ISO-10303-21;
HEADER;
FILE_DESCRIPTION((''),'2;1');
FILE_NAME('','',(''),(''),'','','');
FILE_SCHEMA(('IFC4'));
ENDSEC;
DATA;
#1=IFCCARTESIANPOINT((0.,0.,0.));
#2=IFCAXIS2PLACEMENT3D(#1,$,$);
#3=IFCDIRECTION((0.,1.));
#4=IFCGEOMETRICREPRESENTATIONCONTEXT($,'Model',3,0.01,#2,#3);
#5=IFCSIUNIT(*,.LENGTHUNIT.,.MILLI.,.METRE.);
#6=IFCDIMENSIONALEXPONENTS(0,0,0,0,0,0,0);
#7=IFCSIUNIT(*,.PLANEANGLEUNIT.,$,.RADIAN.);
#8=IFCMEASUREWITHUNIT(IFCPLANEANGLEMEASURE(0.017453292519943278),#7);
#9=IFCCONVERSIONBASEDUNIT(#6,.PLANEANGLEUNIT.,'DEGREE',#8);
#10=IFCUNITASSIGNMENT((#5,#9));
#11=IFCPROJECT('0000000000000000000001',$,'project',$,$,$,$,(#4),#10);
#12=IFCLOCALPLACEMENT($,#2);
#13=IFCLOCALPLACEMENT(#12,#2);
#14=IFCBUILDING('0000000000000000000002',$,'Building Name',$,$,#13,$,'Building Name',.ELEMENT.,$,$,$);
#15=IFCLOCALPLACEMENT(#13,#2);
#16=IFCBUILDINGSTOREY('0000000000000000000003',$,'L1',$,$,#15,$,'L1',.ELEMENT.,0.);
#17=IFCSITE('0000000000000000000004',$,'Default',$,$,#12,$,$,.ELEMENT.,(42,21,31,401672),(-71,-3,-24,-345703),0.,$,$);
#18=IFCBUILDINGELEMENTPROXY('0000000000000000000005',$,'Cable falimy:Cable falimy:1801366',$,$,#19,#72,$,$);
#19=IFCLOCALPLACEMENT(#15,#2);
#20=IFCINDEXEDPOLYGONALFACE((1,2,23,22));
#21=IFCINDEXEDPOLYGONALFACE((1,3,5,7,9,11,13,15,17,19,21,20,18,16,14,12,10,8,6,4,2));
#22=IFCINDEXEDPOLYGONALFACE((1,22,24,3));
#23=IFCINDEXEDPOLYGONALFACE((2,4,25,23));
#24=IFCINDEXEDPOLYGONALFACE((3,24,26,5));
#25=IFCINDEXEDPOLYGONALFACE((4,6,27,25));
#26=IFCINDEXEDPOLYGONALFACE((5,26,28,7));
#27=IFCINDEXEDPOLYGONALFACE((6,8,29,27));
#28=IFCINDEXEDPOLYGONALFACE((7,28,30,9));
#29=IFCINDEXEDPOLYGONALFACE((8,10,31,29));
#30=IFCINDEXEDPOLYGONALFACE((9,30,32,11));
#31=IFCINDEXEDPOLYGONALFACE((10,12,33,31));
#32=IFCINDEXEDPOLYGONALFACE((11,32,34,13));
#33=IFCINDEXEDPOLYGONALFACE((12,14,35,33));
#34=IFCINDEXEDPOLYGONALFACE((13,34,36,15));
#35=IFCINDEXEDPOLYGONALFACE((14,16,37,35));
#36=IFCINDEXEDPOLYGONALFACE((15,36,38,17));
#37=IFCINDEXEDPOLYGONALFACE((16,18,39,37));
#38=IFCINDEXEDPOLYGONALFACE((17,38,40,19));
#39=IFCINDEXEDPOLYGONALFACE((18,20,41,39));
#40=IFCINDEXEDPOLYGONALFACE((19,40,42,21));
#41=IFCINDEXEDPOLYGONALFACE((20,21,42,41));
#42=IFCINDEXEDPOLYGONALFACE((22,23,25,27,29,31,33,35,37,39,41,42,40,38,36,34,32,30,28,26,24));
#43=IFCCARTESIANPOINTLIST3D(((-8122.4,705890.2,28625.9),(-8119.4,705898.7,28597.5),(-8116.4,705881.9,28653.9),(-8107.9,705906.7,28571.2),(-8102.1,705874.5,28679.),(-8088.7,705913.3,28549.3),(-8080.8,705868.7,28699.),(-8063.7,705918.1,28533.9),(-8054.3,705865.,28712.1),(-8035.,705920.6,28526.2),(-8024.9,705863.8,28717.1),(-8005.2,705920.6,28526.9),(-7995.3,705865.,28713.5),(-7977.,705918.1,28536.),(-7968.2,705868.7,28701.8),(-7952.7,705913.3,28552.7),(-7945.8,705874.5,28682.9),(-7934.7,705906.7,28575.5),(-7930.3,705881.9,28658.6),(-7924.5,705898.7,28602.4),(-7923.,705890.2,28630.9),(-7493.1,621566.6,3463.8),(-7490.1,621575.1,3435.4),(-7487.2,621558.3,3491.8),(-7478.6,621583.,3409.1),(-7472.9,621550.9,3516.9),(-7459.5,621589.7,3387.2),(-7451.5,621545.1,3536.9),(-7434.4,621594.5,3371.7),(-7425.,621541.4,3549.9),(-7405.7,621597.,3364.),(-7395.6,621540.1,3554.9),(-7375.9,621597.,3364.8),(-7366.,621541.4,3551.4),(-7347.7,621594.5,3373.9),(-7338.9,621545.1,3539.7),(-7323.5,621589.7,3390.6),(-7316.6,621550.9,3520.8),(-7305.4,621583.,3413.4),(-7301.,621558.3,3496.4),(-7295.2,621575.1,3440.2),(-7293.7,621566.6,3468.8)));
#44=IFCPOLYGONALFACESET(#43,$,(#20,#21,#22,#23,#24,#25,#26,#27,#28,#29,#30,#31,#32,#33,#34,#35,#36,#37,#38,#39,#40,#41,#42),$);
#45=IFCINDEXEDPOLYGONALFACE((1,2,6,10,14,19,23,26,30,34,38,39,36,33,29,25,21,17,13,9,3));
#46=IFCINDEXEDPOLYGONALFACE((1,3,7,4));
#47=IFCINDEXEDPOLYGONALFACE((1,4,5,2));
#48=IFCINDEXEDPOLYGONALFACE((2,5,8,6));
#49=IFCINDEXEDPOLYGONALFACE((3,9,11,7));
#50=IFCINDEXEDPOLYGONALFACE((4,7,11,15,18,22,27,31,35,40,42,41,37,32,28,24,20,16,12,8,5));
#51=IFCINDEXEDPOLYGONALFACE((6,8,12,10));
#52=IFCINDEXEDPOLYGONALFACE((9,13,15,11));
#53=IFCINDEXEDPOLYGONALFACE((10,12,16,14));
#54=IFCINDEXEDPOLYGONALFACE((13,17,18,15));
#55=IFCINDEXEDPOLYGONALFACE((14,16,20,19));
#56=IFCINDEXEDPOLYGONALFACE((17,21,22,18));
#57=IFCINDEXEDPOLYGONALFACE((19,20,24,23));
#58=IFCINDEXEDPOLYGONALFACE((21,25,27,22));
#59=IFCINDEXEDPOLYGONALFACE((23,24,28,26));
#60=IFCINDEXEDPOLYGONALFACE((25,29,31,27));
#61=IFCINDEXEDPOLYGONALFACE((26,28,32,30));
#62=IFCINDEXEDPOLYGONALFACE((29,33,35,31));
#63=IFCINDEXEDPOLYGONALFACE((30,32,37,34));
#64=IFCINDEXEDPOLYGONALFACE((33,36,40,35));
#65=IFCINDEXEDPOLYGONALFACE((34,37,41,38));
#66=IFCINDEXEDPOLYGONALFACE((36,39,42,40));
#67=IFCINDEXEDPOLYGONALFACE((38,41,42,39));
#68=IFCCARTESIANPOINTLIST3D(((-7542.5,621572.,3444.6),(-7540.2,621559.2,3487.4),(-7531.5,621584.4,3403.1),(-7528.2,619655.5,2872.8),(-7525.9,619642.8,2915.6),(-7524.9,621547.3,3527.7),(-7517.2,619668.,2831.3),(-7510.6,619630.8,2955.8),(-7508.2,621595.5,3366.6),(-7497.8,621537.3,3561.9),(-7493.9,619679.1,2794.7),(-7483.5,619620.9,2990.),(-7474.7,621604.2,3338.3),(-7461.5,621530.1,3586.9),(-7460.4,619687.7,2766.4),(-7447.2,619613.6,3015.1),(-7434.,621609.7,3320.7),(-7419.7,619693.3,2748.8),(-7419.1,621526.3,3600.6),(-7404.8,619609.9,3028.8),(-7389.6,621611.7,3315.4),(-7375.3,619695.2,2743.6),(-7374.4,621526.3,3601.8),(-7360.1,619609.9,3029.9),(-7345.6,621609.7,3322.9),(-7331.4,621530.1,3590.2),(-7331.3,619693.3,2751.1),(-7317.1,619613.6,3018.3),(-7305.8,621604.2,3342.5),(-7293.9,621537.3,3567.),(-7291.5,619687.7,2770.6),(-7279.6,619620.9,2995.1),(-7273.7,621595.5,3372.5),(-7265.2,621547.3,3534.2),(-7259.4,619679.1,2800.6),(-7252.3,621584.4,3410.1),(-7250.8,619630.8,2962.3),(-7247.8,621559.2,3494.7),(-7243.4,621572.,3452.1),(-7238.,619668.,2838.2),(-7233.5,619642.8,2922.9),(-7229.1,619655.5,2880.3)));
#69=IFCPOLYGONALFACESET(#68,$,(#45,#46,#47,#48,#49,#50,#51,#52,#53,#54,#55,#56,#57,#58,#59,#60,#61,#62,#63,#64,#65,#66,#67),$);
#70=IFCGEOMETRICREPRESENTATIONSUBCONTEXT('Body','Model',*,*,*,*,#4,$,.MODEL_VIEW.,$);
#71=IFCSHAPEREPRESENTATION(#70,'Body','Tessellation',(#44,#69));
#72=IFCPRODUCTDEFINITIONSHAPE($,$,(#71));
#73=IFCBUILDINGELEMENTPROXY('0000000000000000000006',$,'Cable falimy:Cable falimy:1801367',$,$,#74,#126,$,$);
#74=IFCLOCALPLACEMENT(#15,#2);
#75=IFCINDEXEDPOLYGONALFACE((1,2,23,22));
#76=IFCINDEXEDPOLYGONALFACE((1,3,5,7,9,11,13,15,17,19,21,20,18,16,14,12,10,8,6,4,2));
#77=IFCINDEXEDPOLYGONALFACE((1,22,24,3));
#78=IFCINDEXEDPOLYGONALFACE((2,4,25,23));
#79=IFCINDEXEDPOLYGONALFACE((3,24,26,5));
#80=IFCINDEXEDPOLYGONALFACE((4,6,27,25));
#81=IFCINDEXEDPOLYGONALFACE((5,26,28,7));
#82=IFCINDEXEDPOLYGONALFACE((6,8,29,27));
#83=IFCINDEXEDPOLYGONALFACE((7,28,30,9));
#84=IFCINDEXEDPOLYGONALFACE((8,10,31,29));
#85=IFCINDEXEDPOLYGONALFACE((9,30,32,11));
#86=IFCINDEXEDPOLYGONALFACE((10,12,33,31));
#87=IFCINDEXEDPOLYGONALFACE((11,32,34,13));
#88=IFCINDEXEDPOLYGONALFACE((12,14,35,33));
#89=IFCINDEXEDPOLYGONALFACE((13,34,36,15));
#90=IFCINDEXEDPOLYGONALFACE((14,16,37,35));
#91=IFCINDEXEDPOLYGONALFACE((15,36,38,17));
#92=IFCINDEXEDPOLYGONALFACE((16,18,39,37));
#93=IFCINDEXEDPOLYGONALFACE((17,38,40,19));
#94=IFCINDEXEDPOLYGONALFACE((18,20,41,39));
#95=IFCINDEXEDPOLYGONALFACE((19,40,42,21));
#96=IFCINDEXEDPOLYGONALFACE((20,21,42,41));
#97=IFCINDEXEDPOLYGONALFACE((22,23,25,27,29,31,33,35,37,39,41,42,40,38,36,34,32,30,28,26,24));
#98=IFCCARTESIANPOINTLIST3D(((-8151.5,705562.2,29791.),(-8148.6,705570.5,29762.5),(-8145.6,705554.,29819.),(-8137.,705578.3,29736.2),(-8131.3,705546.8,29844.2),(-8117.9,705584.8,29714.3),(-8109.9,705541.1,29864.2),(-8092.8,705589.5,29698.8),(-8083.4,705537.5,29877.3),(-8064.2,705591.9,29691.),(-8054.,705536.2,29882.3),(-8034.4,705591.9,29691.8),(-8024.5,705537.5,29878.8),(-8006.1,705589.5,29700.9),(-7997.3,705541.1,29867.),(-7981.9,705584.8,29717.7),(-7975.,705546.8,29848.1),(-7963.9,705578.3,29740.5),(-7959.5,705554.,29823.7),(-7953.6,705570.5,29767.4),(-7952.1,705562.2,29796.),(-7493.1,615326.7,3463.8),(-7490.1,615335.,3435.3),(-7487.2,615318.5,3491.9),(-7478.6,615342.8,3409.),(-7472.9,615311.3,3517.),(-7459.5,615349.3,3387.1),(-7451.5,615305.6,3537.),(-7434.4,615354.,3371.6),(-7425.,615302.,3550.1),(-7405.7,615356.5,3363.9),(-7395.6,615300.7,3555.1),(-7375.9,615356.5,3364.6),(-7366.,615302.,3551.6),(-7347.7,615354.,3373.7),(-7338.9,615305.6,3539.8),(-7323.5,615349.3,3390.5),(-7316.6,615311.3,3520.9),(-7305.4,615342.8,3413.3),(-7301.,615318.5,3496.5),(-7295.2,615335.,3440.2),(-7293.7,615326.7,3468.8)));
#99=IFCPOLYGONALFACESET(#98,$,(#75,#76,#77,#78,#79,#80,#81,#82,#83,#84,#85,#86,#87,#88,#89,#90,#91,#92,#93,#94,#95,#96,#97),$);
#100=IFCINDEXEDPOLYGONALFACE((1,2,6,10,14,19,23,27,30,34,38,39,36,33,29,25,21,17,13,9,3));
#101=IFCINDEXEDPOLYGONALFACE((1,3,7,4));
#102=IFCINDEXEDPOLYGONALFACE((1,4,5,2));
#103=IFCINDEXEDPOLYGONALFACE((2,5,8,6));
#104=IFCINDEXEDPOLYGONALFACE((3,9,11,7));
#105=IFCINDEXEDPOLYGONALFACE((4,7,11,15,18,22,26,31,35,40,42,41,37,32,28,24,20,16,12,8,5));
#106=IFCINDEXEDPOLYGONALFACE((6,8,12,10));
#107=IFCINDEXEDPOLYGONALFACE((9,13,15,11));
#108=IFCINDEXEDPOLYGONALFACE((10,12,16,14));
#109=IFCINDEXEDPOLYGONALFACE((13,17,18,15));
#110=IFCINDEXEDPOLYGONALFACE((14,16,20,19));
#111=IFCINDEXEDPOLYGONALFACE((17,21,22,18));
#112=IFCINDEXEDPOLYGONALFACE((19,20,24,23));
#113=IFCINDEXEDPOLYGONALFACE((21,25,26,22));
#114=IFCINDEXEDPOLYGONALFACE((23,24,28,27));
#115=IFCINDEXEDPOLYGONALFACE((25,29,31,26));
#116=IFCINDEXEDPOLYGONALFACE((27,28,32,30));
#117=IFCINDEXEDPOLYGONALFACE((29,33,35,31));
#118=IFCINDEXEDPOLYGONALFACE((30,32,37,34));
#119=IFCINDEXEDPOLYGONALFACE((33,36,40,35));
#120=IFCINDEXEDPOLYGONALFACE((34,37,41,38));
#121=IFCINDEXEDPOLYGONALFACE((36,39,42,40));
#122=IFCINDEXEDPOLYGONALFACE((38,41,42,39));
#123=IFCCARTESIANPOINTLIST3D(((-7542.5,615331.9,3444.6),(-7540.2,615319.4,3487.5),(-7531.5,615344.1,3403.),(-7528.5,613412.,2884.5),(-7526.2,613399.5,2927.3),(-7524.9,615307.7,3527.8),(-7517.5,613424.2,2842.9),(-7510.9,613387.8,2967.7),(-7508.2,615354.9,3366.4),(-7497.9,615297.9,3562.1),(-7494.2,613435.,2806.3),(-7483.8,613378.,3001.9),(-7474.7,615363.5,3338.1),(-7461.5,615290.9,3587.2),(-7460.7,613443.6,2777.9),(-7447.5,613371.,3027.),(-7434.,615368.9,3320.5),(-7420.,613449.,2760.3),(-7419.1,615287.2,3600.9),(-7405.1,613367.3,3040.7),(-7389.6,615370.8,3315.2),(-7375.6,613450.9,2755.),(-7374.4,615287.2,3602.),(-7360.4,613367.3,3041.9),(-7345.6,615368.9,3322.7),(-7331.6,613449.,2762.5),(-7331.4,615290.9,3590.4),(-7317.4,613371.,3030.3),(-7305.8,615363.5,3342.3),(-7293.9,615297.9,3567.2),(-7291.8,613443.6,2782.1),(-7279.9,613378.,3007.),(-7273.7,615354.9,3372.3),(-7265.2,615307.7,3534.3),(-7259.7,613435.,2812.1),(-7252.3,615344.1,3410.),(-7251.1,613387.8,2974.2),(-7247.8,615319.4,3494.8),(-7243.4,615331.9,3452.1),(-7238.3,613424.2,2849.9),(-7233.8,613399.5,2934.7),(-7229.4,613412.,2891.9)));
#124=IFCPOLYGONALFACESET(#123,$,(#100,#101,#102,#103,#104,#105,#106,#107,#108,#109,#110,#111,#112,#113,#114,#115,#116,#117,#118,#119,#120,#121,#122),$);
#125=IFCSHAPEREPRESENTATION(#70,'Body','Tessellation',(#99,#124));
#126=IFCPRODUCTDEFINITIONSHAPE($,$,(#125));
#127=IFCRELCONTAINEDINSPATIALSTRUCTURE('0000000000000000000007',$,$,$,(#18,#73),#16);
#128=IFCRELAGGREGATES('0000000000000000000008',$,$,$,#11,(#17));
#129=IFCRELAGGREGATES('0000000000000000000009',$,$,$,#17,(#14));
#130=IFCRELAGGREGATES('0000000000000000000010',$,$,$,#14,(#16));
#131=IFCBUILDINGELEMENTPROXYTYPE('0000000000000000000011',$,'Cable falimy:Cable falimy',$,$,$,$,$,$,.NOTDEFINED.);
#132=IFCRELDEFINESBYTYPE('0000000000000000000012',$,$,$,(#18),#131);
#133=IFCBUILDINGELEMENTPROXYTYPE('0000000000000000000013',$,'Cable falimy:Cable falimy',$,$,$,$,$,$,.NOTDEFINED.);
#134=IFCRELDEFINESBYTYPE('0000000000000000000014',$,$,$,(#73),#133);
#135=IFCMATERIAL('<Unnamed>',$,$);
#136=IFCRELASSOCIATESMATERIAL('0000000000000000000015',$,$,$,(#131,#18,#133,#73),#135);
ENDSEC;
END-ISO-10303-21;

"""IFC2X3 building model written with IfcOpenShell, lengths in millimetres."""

from ifc_helpers import new_model, entity, si_unit, converted_unit, direction, frame, frame_2d, origin, place, context, subcontext, project, spatial, circle, extrude, source, transform, mapped, material, type_object, type_shapes, element, save


model = new_model("IFC2X3")

# Units and contexts
model_context = context("Model", 3, precision=0.01, world=origin(), true_north=direction((0.0, 1.0)))
body_context = subcontext(model_context, "Body", "Model", "MODEL_VIEW")
ifc_project = project(units=[si_unit("LENGTHUNIT", "METRE", prefix="MILLI"), converted_unit("PLANEANGLEUNIT", "DEGREE", entity("IfcPlaneAngleMeasure", 0.017453292519943278), si_unit("PLANEANGLEUNIT", "RADIAN"), dimensions=[0, 0, 0, 0, 0, 0, 0])], contexts=[model_context])

# Site, building, storey
site_placement = place(None, origin())
site = spatial("IfcSite", under=ifc_project, at=site_placement, Name="Default", CompositionType="ELEMENT", RefLatitude=(42, 21, 31, 401672), RefLongitude=(-71, -3, -24, -345703), RefElevation=0.0)
building_placement = place(site_placement, origin())
building = spatial("IfcBuilding", under=site, at=building_placement, Name="Building Name", LongName="Building Name", CompositionType="ELEMENT")
storey_placement = place(building_placement, origin())
storey = spatial("IfcBuildingStorey", under=building, at=storey_placement, Name="L1", LongName="L1", CompositionType="ELEMENT", Elevation=0.0)

# Shared definitions
ifc_material = material(Name="<Unnamed>")

# Building element proxies
building_element_proxy_type_1 = type_object("IfcBuildingElementProxyType", Name="Cable falimy:Cable falimy", PredefinedType="NOTDEFINED", material=ifc_material)
shared_shape_1 = source(origin(), body_context, "Body", "SweptSolid", [
    extrude(circle(Radius=100.0, at=frame_2d((0.0, 0.0), x_axis=(1.0, 0.0))), frame((0.0, 0.0, 0.0), z_axis=(0.958223, 0.0, 0.286023), x_axis=(-0.286023, 0.0, 0.958223)), (0.0, 0.0, 1.0), 88000.0),
    extrude(circle(Radius=150.0, at=frame_2d((0.0, 0.0), x_axis=(1.0, 0.0))), frame((-1916.4, 0.0, -572.0), z_axis=(0.958223, 0.0, 0.286023), x_axis=(0.286023, 0.0, -0.958223)), (0.0, 0.0, 1.0), 2000.0),
])
type_shapes(building_element_proxy_type_1, [shared_shape_1])
proxy_1_placement = place(storey_placement, frame((-7393.2, 621568.7, 3459.1), z_axis=(-0.025001, 0.0, 0.999687), x_axis=(0.0, 1.0, 0.0)))
element("IfcBuildingElementProxy", 1, at=proxy_1_placement, inside=storey, type_object=building_element_proxy_type_1, material=ifc_material, Name="Cable falimy:Cable falimy:1801366", context=body_context, shape_type="MappedRepresentation", body=[
    mapped(shared_shape_1, transform((0.0, 0.0, 0.0), scale=1.0)),
])
building_element_proxy_type_2 = type_object("IfcBuildingElementProxyType", Name="Cable falimy:Cable falimy", PredefinedType="NOTDEFINED", material=ifc_material)
shared_shape_2 = source(origin(), body_context, "Body", "SweptSolid", [
    extrude(circle(Radius=100.0, at=frame_2d((0.0, 0.0), x_axis=(1.0, 0.0))), frame((0.0, 0.0, 0.0), z_axis=(0.959952, 0.0, 0.280164), x_axis=(-0.280164, 0.0, 0.959952)), (0.0, 0.0, 1.0), 94000.0),
    extrude(circle(Radius=150.0, at=frame_2d((0.0, 0.0), x_axis=(1.0, 0.0))), frame((-1919.9, 0.0, -560.3), z_axis=(0.959952, 0.0, 0.280164), x_axis=(0.280164, 0.0, -0.959952)), (0.0, 0.0, 1.0), 2000.0),
])
type_shapes(building_element_proxy_type_2, [shared_shape_2])
proxy_2_placement = place(storey_placement, frame((-7393.2, 615328.7, 3459.1), z_axis=(-0.025001, 0.0, 0.999687), x_axis=(0.0, 1.0, 0.0)))
element("IfcBuildingElementProxy", 2, at=proxy_2_placement, inside=storey, type_object=building_element_proxy_type_2, material=ifc_material, Name="Cable falimy:Cable falimy:1801367", context=body_context, shape_type="MappedRepresentation", body=[
    mapped(shared_shape_2, transform((0.0, 0.0, 0.0), scale=1.0)),
])

save(model, "model.ifc")
